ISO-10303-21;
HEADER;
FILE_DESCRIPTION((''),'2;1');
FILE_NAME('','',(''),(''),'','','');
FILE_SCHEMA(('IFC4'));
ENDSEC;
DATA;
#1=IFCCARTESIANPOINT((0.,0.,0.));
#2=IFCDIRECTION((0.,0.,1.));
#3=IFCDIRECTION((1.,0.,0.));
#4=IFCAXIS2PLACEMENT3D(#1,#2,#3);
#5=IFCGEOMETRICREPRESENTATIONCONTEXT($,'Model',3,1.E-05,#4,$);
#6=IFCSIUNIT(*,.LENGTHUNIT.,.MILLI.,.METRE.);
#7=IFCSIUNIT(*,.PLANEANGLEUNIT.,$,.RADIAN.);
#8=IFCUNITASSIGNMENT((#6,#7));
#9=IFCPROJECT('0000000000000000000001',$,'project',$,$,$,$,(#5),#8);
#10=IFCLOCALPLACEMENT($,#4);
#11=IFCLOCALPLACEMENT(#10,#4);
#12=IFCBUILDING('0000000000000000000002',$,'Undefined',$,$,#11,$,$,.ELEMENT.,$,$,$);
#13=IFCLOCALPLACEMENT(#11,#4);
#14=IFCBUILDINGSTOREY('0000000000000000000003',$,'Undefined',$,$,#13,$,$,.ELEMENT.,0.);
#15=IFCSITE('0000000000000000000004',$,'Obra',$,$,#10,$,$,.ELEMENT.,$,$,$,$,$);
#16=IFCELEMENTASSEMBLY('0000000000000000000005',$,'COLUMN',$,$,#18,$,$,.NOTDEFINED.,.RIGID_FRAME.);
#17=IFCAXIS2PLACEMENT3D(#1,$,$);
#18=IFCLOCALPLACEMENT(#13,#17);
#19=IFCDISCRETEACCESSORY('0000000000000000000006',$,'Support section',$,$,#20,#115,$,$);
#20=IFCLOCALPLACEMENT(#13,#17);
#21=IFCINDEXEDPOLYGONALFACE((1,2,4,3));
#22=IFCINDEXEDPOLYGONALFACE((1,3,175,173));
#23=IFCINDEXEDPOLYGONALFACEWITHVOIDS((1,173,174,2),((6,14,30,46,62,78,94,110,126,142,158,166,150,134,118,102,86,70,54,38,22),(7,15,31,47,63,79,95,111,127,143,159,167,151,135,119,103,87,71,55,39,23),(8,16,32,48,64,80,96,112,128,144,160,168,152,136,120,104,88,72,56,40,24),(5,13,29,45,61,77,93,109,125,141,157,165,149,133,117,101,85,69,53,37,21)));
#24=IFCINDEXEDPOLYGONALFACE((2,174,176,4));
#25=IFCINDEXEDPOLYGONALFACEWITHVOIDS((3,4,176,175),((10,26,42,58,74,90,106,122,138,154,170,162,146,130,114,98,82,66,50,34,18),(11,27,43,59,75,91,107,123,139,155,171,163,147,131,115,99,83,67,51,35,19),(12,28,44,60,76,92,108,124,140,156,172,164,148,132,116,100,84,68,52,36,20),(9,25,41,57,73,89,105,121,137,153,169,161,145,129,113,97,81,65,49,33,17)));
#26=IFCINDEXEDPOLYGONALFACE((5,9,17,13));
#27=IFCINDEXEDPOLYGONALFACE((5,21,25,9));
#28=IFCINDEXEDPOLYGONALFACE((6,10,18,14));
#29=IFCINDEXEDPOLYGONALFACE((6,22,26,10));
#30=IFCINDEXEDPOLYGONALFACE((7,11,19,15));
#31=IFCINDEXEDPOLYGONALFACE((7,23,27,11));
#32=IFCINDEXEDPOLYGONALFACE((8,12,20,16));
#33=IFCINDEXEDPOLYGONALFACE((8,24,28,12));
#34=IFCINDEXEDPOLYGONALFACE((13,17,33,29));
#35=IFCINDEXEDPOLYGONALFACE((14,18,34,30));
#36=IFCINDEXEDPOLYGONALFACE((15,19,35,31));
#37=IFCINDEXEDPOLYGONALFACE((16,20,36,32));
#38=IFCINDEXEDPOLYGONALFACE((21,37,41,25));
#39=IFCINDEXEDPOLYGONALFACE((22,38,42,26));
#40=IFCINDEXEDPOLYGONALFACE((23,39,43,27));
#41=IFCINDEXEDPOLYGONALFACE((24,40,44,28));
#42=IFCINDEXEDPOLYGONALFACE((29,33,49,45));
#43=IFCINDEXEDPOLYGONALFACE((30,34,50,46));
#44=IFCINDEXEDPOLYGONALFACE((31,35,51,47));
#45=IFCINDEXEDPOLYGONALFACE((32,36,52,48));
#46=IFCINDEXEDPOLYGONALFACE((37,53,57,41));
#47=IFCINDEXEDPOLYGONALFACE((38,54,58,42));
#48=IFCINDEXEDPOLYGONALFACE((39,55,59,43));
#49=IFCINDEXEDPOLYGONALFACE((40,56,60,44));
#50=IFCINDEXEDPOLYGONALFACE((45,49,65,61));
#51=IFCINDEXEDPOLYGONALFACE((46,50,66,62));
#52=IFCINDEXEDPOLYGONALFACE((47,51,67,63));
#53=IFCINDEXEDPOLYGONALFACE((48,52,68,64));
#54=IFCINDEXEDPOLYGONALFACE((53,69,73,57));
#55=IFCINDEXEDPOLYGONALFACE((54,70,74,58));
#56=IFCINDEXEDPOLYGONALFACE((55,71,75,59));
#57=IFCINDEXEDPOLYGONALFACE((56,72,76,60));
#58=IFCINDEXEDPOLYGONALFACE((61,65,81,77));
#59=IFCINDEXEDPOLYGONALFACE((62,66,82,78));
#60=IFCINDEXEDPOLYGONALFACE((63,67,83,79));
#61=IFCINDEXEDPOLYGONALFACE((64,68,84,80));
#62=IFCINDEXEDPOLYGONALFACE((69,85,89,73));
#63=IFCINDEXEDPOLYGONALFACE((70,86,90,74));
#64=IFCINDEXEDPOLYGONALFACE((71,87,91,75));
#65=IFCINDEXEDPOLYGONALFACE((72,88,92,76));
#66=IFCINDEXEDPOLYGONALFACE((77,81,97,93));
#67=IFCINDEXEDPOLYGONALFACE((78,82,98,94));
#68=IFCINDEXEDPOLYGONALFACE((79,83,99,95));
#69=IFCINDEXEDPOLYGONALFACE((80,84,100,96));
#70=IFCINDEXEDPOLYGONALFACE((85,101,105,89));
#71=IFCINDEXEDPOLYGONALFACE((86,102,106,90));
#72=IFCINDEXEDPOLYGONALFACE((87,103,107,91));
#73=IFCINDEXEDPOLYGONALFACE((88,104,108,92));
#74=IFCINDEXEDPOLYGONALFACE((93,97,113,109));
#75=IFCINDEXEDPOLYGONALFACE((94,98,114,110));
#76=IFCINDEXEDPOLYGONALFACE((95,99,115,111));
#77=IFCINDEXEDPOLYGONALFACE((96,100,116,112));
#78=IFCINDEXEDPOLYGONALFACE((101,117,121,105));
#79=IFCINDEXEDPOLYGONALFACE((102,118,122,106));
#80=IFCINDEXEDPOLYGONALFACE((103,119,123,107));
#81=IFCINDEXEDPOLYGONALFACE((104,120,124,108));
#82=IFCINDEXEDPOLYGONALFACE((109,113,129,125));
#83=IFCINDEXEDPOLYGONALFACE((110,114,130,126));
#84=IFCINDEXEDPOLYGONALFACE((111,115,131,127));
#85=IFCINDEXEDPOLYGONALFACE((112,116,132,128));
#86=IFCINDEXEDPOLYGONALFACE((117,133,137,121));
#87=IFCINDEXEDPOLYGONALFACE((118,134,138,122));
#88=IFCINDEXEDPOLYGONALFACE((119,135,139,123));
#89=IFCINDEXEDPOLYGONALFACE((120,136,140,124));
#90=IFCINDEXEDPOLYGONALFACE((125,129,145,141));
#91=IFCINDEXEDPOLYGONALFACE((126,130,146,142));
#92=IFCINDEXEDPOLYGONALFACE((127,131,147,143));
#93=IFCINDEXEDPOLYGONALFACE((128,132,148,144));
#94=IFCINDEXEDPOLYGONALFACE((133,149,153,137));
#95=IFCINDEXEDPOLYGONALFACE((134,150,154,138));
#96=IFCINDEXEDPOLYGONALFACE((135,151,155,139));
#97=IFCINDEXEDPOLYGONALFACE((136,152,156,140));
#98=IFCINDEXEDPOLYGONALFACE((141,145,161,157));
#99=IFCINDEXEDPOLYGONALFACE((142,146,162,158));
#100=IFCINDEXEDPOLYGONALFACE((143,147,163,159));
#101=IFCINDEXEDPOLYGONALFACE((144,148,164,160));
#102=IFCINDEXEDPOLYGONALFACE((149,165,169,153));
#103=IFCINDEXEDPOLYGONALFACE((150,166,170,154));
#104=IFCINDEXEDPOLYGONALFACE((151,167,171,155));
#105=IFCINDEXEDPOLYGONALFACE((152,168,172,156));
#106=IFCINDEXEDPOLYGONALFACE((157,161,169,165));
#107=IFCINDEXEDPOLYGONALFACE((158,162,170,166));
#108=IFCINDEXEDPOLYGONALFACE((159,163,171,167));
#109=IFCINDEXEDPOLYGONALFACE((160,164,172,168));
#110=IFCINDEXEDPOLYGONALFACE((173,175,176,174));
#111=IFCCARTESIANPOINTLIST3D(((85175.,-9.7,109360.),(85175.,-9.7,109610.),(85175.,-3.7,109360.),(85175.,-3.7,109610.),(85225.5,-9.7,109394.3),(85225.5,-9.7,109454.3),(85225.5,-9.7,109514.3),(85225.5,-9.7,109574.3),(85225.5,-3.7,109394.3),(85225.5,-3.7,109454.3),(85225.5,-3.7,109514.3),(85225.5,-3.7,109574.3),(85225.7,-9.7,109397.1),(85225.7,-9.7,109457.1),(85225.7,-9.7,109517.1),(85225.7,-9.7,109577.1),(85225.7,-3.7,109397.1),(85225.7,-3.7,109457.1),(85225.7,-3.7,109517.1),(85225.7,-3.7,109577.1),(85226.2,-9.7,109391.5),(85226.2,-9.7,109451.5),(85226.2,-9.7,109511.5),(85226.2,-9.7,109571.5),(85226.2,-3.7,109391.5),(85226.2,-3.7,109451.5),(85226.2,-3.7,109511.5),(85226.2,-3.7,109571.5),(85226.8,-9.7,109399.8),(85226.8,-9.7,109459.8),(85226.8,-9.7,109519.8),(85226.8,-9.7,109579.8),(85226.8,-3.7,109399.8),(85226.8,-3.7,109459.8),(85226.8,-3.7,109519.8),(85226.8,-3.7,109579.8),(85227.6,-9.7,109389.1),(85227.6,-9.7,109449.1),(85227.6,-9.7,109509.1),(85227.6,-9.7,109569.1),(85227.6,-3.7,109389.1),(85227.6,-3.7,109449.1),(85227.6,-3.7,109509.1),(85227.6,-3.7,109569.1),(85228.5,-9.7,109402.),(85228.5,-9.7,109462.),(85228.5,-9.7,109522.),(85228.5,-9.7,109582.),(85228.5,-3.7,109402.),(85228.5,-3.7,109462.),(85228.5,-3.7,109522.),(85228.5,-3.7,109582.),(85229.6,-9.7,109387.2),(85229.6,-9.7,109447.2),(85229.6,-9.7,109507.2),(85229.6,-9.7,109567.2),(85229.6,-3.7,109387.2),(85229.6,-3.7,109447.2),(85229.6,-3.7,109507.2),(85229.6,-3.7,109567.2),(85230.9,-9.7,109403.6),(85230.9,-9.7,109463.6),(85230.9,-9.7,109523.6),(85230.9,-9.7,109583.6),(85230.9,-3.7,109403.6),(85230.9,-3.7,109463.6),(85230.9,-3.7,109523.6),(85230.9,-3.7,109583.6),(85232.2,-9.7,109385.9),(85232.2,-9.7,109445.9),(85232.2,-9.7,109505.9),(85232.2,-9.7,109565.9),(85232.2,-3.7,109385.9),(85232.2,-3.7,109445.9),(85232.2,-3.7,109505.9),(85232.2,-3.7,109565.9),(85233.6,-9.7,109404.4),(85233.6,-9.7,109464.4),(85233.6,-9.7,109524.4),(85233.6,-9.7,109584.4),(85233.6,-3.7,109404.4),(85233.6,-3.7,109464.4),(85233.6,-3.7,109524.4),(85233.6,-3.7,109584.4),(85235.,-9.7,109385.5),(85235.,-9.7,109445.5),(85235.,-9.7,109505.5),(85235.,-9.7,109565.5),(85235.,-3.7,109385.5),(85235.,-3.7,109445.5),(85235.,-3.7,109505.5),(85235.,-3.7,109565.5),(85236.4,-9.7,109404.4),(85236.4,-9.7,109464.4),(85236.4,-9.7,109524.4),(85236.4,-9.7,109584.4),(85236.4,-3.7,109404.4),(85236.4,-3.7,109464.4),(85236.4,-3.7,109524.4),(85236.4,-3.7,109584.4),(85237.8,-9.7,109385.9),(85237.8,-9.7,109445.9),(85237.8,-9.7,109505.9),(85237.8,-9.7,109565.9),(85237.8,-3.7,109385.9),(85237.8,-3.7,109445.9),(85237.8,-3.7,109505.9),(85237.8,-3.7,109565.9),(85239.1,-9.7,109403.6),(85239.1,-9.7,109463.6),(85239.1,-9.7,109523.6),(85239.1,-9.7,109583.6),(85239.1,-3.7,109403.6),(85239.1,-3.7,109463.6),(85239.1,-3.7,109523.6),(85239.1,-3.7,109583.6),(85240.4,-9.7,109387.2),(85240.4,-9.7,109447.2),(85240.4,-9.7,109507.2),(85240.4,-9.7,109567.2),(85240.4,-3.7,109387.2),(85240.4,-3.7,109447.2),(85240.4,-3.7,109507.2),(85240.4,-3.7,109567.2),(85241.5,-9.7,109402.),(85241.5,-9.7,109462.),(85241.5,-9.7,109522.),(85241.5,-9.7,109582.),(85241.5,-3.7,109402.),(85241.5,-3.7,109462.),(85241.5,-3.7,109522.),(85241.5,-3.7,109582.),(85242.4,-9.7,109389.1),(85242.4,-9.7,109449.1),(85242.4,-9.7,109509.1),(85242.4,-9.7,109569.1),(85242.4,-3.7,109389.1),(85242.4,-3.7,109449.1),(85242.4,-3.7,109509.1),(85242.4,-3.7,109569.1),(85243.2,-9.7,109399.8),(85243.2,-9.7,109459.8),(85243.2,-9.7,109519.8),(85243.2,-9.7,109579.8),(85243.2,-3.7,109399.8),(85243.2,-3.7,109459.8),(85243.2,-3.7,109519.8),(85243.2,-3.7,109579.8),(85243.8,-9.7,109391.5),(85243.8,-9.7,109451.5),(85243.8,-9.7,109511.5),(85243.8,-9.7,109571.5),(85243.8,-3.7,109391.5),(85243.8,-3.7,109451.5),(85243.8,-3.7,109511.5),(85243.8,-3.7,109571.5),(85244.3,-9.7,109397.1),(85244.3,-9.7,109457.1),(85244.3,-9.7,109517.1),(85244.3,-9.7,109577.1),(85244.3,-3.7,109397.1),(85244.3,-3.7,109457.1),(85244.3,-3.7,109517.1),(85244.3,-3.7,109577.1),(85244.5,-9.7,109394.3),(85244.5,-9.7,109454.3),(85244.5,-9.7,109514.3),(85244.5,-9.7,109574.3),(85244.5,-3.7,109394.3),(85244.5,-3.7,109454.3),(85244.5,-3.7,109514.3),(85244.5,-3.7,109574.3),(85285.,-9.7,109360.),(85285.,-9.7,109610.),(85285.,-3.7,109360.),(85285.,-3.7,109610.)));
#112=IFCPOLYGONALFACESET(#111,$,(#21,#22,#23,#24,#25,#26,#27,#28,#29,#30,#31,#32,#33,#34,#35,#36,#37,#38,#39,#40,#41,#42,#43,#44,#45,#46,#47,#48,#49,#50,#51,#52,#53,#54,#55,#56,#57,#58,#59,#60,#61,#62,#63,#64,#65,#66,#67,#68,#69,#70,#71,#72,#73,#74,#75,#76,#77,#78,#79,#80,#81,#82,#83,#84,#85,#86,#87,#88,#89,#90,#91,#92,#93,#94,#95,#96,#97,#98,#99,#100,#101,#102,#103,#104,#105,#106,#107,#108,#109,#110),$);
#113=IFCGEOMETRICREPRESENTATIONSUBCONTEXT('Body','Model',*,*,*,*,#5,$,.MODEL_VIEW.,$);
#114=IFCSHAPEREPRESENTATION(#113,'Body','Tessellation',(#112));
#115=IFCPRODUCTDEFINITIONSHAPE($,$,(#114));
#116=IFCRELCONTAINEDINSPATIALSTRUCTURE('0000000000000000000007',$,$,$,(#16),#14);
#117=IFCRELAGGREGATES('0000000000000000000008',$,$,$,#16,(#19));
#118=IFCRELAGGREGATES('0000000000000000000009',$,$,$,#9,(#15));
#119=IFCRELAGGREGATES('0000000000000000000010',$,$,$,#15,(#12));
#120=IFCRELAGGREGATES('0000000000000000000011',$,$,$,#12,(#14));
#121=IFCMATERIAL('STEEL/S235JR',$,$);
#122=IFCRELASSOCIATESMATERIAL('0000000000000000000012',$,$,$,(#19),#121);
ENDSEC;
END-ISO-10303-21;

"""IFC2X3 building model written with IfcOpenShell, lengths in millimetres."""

from ifc_helpers import new_model, si_unit, frame, origin_with_axes, origin_2d_with_axis, place, context, subcontext, project, spatial, rectangle, circle, extrude, source, transform, mapped, material, element, aggregate, save


model = new_model("IFC2X3")

# Units and contexts
model_context = context("Model", 3, precision=1e-05, world=origin_with_axes())
body_context = subcontext(model_context, "Body", "Model", "MODEL_VIEW")
ifc_project = project(units=[si_unit("LENGTHUNIT", "METRE", prefix="MILLI"), si_unit("PLANEANGLEUNIT", "RADIAN")], contexts=[model_context])

# Site, building, storey
site_placement = place(None, origin_with_axes())
site = spatial("IfcSite", under=ifc_project, at=site_placement, Name="Obra", CompositionType="ELEMENT")
building_placement = place(site_placement, origin_with_axes())
building = spatial("IfcBuilding", under=site, at=building_placement, Name="Undefined", CompositionType="ELEMENT")
storey_placement = place(building_placement, origin_with_axes())
storey = spatial("IfcBuildingStorey", under=building, at=storey_placement, Name="Undefined", CompositionType="ELEMENT", Elevation=0.0)

# Element assembly, discrete accessory, opening
assembly_1_placement = place(storey_placement, origin_with_axes())
assembly_1 = element("IfcElementAssembly", 1, at=assembly_1_placement, inside=storey, Name="COLUMN", AssemblyPlace="NOTDEFINED", PredefinedType="RIGID_FRAME")
ifc_material_1 = material(Name="STEEL/S235JR")
shared_shape_1 = source(origin_with_axes(), body_context, "Body", "SweptSolid", [
    extrude(circle(Radius=9.5, at=origin_2d_with_axis()), frame((0.0, -9.8, 0.0), z_axis=(0.0, 1.0, 0.0), x_axis=(1.0, 0.0, 0.0)), (0.0, 0.0, 1.0), 6.2),
])
discrete_accessory_1_placement = place(assembly_1_placement, frame((85230.0, -6.7, 109360.0), z_axis=(0.0, 0.0, 1.0), x_axis=(-1.0, 0.0, 0.0)))
discrete_accessory_1 = element("IfcDiscreteAccessory", 2, at=discrete_accessory_1_placement, material=ifc_material_1, Name="Support section", context=body_context, shape_type="SweptSolid", body=[
    extrude(rectangle(XDim=6.0, YDim=110.0, at=origin_2d_with_axis()), frame((0.0, 0.0, 250.0), z_axis=(0.0, 0.0, -1.0), x_axis=(0.0, 1.0, 0.0)), (0.0, 0.0, 1.0), 250.0),
])
opening_1_placement = place(assembly_1_placement, frame((85185.0, 0.0, 109650.0), z_axis=(1.0, 0.0, 0.0), x_axis=(0.0, 0.0, -1.0)))
element("IfcOpeningElement", 3, at=opening_1_placement, cuts=discrete_accessory_1, ObjectType="Opening", context=body_context, shape_type="MappedRepresentation", body=[
    mapped(shared_shape_1, transform((75.0, 0.0, 50.0))),
    mapped(shared_shape_1, transform((135.0, 0.0, 50.0))),
    mapped(shared_shape_1, transform((195.0, 0.0, 50.0))),
    mapped(shared_shape_1, transform((255.0, 0.0, 50.0))),
])
aggregate(assembly_1, [discrete_accessory_1])

save(model, "model.ifc")
